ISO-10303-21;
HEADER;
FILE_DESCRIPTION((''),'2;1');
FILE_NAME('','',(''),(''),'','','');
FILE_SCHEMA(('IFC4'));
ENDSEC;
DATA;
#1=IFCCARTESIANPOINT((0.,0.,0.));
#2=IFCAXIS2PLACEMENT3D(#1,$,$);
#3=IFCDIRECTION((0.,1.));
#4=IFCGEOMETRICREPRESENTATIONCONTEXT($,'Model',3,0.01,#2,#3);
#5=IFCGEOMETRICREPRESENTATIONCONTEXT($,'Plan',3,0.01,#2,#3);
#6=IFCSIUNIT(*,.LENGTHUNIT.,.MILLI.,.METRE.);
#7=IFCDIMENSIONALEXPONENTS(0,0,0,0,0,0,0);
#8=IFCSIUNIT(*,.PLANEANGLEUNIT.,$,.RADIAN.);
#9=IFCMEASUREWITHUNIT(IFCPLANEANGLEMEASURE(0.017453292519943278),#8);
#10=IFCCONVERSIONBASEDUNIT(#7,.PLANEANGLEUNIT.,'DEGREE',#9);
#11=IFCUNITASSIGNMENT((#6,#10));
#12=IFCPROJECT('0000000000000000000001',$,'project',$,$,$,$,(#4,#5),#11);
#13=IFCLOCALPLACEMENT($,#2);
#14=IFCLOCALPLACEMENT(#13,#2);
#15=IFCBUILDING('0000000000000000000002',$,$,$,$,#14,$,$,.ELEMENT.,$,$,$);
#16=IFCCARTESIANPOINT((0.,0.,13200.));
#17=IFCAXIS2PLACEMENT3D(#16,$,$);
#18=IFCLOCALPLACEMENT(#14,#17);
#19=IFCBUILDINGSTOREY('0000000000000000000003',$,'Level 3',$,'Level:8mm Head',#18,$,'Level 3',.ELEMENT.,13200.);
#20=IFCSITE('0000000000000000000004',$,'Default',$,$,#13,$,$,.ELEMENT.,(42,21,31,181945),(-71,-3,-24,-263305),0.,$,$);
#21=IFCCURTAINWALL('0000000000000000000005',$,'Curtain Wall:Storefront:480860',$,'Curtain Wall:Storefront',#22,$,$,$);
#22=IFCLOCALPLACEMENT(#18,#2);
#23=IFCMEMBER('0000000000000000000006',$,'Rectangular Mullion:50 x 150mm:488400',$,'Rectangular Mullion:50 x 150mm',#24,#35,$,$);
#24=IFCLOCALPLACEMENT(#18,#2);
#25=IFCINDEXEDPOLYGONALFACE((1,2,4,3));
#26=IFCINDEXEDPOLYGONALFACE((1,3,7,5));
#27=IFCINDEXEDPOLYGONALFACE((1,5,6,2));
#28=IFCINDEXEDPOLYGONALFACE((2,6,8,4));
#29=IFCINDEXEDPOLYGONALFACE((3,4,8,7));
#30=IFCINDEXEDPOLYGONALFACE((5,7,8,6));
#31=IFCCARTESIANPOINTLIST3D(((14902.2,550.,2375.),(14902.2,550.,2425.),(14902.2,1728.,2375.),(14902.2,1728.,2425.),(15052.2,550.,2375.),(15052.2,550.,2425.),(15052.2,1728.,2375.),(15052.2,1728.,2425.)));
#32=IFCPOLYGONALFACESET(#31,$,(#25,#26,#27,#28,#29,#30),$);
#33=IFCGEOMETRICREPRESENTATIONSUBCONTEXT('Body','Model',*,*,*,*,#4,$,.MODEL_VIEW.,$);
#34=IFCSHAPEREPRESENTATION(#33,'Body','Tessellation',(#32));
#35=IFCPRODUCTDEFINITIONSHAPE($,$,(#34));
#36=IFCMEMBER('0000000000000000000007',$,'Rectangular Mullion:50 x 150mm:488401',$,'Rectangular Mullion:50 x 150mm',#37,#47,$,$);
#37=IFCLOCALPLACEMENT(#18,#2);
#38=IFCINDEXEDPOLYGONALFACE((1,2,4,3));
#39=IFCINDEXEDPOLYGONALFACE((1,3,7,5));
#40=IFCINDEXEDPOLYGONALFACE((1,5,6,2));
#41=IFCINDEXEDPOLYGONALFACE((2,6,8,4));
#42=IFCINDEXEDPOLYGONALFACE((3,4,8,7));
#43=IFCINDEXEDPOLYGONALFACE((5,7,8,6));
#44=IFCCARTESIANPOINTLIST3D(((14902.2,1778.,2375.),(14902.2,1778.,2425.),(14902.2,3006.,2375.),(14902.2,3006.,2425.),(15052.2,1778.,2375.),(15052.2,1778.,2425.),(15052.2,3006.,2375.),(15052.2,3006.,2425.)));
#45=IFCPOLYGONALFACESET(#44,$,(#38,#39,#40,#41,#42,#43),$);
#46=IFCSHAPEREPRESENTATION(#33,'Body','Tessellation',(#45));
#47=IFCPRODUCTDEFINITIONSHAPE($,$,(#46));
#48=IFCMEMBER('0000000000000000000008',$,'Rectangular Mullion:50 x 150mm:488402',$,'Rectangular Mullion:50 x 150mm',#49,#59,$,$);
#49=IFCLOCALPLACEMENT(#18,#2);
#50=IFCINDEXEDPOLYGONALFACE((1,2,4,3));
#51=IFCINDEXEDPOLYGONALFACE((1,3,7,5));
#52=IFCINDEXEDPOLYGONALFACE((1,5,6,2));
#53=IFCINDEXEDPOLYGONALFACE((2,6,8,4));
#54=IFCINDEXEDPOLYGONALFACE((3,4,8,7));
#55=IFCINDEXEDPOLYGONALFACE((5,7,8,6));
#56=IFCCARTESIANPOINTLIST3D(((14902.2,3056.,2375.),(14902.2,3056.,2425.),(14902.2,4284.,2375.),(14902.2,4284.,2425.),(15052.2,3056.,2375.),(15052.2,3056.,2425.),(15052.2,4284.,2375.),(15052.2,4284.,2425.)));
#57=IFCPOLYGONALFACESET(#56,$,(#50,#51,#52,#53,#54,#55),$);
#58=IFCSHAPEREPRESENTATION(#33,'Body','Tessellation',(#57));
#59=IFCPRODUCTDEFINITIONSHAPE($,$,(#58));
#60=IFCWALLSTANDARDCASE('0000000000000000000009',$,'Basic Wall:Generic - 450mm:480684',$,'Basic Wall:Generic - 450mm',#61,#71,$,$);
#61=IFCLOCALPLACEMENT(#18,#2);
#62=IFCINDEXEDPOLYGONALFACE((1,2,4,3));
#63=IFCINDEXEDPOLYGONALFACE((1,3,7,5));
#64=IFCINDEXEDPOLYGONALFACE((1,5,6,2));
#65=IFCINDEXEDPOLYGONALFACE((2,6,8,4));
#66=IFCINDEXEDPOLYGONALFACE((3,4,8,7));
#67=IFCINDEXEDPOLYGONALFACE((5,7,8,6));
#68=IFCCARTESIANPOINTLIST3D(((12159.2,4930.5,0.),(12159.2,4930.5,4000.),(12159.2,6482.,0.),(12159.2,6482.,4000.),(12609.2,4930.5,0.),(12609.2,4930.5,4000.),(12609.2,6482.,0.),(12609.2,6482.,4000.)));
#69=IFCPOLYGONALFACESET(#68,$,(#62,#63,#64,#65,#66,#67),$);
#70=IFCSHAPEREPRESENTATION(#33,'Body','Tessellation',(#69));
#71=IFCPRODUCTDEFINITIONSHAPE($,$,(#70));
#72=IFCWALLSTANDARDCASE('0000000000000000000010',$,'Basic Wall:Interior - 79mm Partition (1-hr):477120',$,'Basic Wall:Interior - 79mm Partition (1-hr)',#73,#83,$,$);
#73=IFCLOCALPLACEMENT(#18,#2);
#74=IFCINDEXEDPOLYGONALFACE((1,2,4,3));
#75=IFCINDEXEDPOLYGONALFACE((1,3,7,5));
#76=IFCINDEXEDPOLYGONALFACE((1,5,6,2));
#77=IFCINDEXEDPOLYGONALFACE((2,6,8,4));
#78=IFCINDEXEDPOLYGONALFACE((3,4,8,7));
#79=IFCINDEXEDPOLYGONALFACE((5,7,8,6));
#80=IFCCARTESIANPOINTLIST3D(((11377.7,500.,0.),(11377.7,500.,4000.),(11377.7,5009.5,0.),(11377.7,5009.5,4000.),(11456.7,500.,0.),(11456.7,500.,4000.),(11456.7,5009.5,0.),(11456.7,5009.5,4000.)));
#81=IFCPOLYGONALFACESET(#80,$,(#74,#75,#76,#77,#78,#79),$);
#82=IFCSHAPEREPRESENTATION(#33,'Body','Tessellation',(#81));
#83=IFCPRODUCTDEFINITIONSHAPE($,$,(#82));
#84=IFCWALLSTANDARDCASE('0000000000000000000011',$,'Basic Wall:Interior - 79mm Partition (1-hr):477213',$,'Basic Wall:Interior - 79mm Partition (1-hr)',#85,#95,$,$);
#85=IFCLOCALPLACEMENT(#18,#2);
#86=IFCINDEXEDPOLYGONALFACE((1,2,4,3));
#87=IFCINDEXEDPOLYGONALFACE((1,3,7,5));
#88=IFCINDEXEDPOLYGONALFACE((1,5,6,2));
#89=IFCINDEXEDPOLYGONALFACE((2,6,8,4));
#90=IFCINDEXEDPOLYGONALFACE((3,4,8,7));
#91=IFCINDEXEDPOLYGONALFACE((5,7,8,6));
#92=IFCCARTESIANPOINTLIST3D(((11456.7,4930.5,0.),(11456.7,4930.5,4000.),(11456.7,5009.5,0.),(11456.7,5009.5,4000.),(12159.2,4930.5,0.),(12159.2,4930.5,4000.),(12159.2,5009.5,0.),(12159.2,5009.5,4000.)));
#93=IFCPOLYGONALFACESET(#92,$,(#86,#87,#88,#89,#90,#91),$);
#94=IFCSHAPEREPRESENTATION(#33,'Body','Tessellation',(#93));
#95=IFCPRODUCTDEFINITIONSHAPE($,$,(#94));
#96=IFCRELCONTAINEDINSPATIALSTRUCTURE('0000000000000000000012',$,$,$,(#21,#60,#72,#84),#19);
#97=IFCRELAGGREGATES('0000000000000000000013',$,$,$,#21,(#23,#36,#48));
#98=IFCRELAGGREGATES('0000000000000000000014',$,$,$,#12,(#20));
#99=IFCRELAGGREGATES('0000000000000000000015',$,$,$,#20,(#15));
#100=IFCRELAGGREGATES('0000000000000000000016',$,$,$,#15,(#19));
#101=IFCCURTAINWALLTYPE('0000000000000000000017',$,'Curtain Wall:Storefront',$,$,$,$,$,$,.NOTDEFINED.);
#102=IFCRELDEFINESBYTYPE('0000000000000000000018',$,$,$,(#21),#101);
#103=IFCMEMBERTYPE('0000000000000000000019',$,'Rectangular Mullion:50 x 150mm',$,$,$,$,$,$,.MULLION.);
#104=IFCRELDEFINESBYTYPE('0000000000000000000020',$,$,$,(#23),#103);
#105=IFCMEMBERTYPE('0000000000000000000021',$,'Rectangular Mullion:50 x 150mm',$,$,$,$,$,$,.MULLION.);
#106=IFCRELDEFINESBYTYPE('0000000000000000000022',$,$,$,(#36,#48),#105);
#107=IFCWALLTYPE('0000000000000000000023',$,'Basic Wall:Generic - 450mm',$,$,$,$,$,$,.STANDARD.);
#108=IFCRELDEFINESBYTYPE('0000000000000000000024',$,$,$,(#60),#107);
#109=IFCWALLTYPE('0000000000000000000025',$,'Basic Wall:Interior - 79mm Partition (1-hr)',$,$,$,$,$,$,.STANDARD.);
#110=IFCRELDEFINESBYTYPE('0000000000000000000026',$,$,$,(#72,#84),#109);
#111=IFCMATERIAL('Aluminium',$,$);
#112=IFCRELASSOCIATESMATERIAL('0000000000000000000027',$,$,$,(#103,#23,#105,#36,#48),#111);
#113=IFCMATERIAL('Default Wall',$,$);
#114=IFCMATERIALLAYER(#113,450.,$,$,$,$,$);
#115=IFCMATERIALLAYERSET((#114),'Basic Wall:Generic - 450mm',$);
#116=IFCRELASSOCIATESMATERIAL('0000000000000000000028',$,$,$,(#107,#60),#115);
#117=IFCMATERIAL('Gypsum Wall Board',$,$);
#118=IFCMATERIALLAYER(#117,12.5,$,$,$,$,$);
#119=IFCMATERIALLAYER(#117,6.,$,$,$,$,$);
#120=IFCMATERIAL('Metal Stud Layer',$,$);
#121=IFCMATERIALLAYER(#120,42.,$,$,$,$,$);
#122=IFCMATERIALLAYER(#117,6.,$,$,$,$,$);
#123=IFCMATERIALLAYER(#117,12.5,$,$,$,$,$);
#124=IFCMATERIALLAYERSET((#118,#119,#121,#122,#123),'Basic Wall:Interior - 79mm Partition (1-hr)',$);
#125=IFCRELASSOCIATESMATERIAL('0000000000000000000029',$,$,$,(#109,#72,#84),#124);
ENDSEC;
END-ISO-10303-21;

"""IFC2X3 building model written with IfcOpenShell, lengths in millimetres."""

from ifc_helpers import new_model, entity, si_unit, converted_unit, direction, frame, frame_2d, origin, origin_2d_with_axis, place, context, subcontext, project, spatial, rectangle, extrude, source, transform, mapped, material, layer, layer_set, layer_usage, type_object, type_shapes, element, aggregate, save


model = new_model("IFC2X3")

# Units and contexts
model_context = context("Model", 3, precision=0.01, world=origin(), true_north=direction((0.0, 1.0)))
plan_context = context("Plan", 3, precision=0.01, world=origin(), true_north=direction((0.0, 1.0)))
body_context = subcontext(model_context, "Body", "Model", "MODEL_VIEW")
ifc_project = project(units=[si_unit("LENGTHUNIT", "METRE", prefix="MILLI"), converted_unit("PLANEANGLEUNIT", "DEGREE", entity("IfcPlaneAngleMeasure", 0.017453292519943278), si_unit("PLANEANGLEUNIT", "RADIAN"), dimensions=[0, 0, 0, 0, 0, 0, 0])], contexts=[model_context, plan_context])

# Site, building, storey
site_placement = place(None, origin())
site = spatial("IfcSite", under=ifc_project, at=site_placement, Name="Default", CompositionType="ELEMENT", RefLatitude=(42, 21, 31, 181945), RefLongitude=(-71, -3, -24, -263305), RefElevation=0.0)
building_placement = place(site_placement, origin())
building = spatial("IfcBuilding", under=site, at=building_placement, CompositionType="ELEMENT")
storey_placement = place(building_placement, frame((0.0, 0.0, 13200.0)))
storey = spatial("IfcBuildingStorey", under=building, at=storey_placement, Name="Level 3", ObjectType="Level:8mm Head", LongName="Level 3", CompositionType="ELEMENT", Elevation=13200.0)

# Curtain wall, members
curtain_wall_type = type_object("IfcCurtainWallType", Name="Curtain Wall:Storefront", PredefinedType="NOTDEFINED")
curtain_wall_placement = place(storey_placement, frame((0.0, 0.0, -13200.0)))
curtain_wall = element("IfcCurtainWall", 1, at=curtain_wall_placement, inside=storey, type_object=curtain_wall_type, Name="Curtain Wall:Storefront:480860", ObjectType="Curtain Wall:Storefront")
ifc_material_1 = material(Name="Aluminium")
member_type_1 = type_object("IfcMemberType", Name="Rectangular Mullion:50 x 150mm", PredefinedType="MULLION", material=ifc_material_1)
shared_shape_1 = source(origin(), body_context, "Body", "SweptSolid", [
    extrude(rectangle(XDim=50.0, YDim=150.0, at=origin_2d_with_axis()), frame((0.0, 0.0, -1178.0), z_axis=(0.0, 0.0, 1.0), x_axis=(-1.0, 0.0, 0.0)), (0.0, 0.0, 1.0), 1178.0),
])
type_shapes(member_type_1, [shared_shape_1])
member_1_placement = place(curtain_wall_placement, frame((14977.2, 1728.0, 15600.0), z_axis=(0.0, 1.0, 0.0), x_axis=(0.0, 0.0, 1.0)))
member_1 = element("IfcMember", 2, at=member_1_placement, type_object=member_type_1, material=ifc_material_1, Name="Rectangular Mullion:50 x 150mm:488400", ObjectType="Rectangular Mullion:50 x 150mm", context=body_context, shape_type="MappedRepresentation", body=[
    mapped(shared_shape_1, transform((0.0, 0.0, 0.0), scale=1.0)),
])
member_type_2 = type_object("IfcMemberType", Name="Rectangular Mullion:50 x 150mm", PredefinedType="MULLION", material=ifc_material_1)
shared_shape_2 = source(origin(), body_context, "Body", "SweptSolid", [
    extrude(rectangle(XDim=50.0, YDim=150.0, at=origin_2d_with_axis()), frame((0.0, 0.0, -1228.0), z_axis=(0.0, 0.0, 1.0), x_axis=(-1.0, 0.0, 0.0)), (0.0, 0.0, 1.0), 1228.0),
])
type_shapes(member_type_2, [shared_shape_2])
member_2_placement = place(curtain_wall_placement, frame((14977.2, 3006.0, 15600.0), z_axis=(0.0, 1.0, 0.0), x_axis=(0.0, 0.0, 1.0)))
member_2 = element("IfcMember", 3, at=member_2_placement, type_object=member_type_2, material=ifc_material_1, Name="Rectangular Mullion:50 x 150mm:488401", ObjectType="Rectangular Mullion:50 x 150mm", context=body_context, shape_type="MappedRepresentation", body=[
    mapped(shared_shape_2, transform((0.0, 0.0, 0.0), scale=1.0)),
])
member_3_placement = place(curtain_wall_placement, frame((14977.2, 4284.0, 15600.0), z_axis=(0.0, 1.0, 0.0), x_axis=(0.0, 0.0, 1.0)))
member_3 = element("IfcMember", 4, at=member_3_placement, type_object=member_type_2, material=ifc_material_1, Name="Rectangular Mullion:50 x 150mm:488402", ObjectType="Rectangular Mullion:50 x 150mm", context=body_context, shape_type="MappedRepresentation", body=[
    mapped(shared_shape_2, transform((0.0, 0.0, 0.0), scale=1.0)),
])

# Walls
ifc_material_2 = material(Name="Default Wall")
ifc_layer_1 = layer(ifc_material_2, 450.0)
ifc_layer_set_1 = layer_set([ifc_layer_1], Name="Basic Wall:Generic - 450mm")
ifc_layer_usage_1 = layer_usage(ifc_layer_set_1, "AXIS2", "NEGATIVE", 225.0)
wall_type_1 = type_object("IfcWallType", Name="Basic Wall:Generic - 450mm", PredefinedType="STANDARD", material=ifc_layer_set_1)
wall_1_placement = place(storey_placement, frame((12384.2, 4930.5, 0.0), z_axis=(0.0, 0.0, 1.0), x_axis=(0.0, 1.0, 0.0)))
element("IfcWallStandardCase", 5, at=wall_1_placement, inside=storey, type_object=wall_type_1, material=ifc_layer_usage_1, Name="Basic Wall:Generic - 450mm:480684", ObjectType="Basic Wall:Generic - 450mm", context=body_context, shape_type="SweptSolid", body=[
    extrude(rectangle(XDim=1551.5, YDim=450.0, at=frame_2d((775.8, 0.0), x_axis=(-1.0, 0.0))), origin(), (0.0, 0.0, 1.0), 4000.0),
])
ifc_material_3 = material(Name="Gypsum Wall Board")
ifc_layer_2 = layer(ifc_material_3, 12.5)
ifc_layer_3 = layer(ifc_material_3, 6.0)
ifc_material_4 = material(Name="Metal Stud Layer")
ifc_layer_4 = layer(ifc_material_4, 42.0)
ifc_layer_5 = layer(ifc_material_3, 6.0)
ifc_layer_6 = layer(ifc_material_3, 12.5)
ifc_layer_set_2 = layer_set([ifc_layer_2, ifc_layer_3, ifc_layer_4, ifc_layer_5, ifc_layer_6], Name="Basic Wall:Interior - 79mm Partition (1-hr)")
ifc_layer_usage_2 = layer_usage(ifc_layer_set_2, "AXIS2", "NEGATIVE", 39.5)
wall_type_2 = type_object("IfcWallType", Name="Basic Wall:Interior - 79mm Partition (1-hr)", PredefinedType="STANDARD", material=ifc_layer_set_2)
wall_2_placement = place(storey_placement, frame((11417.2, 500.0, 0.0), z_axis=(0.0, 0.0, 1.0), x_axis=(0.0, 1.0, 0.0)))
element("IfcWallStandardCase", 6, at=wall_2_placement, inside=storey, type_object=wall_type_2, material=ifc_layer_usage_2, Name="Basic Wall:Interior - 79mm Partition (1-hr):477120", ObjectType="Basic Wall:Interior - 79mm Partition (1-hr)", context=body_context, shape_type="SweptSolid", body=[
    extrude(rectangle(XDim=4509.5, YDim=79.0, at=frame_2d((2254.7, 0.0), x_axis=(-1.0, 0.0))), origin(), (0.0, 0.0, 1.0), 4000.0),
])
wall_3_placement = place(storey_placement, frame((11456.7, 4970.0, 0.0)))
element("IfcWallStandardCase", 7, at=wall_3_placement, inside=storey, type_object=wall_type_2, material=ifc_layer_usage_2, Name="Basic Wall:Interior - 79mm Partition (1-hr):477213", ObjectType="Basic Wall:Interior - 79mm Partition (1-hr)", context=body_context, shape_type="SweptSolid", body=[
    extrude(rectangle(XDim=702.5, YDim=79.0, at=frame_2d((351.3, 0.0), x_axis=(-1.0, 0.0))), origin(), (0.0, 0.0, 1.0), 4000.0),
])

aggregate(curtain_wall, [member_1, member_2, member_3])

save(model, "model.ifc")
